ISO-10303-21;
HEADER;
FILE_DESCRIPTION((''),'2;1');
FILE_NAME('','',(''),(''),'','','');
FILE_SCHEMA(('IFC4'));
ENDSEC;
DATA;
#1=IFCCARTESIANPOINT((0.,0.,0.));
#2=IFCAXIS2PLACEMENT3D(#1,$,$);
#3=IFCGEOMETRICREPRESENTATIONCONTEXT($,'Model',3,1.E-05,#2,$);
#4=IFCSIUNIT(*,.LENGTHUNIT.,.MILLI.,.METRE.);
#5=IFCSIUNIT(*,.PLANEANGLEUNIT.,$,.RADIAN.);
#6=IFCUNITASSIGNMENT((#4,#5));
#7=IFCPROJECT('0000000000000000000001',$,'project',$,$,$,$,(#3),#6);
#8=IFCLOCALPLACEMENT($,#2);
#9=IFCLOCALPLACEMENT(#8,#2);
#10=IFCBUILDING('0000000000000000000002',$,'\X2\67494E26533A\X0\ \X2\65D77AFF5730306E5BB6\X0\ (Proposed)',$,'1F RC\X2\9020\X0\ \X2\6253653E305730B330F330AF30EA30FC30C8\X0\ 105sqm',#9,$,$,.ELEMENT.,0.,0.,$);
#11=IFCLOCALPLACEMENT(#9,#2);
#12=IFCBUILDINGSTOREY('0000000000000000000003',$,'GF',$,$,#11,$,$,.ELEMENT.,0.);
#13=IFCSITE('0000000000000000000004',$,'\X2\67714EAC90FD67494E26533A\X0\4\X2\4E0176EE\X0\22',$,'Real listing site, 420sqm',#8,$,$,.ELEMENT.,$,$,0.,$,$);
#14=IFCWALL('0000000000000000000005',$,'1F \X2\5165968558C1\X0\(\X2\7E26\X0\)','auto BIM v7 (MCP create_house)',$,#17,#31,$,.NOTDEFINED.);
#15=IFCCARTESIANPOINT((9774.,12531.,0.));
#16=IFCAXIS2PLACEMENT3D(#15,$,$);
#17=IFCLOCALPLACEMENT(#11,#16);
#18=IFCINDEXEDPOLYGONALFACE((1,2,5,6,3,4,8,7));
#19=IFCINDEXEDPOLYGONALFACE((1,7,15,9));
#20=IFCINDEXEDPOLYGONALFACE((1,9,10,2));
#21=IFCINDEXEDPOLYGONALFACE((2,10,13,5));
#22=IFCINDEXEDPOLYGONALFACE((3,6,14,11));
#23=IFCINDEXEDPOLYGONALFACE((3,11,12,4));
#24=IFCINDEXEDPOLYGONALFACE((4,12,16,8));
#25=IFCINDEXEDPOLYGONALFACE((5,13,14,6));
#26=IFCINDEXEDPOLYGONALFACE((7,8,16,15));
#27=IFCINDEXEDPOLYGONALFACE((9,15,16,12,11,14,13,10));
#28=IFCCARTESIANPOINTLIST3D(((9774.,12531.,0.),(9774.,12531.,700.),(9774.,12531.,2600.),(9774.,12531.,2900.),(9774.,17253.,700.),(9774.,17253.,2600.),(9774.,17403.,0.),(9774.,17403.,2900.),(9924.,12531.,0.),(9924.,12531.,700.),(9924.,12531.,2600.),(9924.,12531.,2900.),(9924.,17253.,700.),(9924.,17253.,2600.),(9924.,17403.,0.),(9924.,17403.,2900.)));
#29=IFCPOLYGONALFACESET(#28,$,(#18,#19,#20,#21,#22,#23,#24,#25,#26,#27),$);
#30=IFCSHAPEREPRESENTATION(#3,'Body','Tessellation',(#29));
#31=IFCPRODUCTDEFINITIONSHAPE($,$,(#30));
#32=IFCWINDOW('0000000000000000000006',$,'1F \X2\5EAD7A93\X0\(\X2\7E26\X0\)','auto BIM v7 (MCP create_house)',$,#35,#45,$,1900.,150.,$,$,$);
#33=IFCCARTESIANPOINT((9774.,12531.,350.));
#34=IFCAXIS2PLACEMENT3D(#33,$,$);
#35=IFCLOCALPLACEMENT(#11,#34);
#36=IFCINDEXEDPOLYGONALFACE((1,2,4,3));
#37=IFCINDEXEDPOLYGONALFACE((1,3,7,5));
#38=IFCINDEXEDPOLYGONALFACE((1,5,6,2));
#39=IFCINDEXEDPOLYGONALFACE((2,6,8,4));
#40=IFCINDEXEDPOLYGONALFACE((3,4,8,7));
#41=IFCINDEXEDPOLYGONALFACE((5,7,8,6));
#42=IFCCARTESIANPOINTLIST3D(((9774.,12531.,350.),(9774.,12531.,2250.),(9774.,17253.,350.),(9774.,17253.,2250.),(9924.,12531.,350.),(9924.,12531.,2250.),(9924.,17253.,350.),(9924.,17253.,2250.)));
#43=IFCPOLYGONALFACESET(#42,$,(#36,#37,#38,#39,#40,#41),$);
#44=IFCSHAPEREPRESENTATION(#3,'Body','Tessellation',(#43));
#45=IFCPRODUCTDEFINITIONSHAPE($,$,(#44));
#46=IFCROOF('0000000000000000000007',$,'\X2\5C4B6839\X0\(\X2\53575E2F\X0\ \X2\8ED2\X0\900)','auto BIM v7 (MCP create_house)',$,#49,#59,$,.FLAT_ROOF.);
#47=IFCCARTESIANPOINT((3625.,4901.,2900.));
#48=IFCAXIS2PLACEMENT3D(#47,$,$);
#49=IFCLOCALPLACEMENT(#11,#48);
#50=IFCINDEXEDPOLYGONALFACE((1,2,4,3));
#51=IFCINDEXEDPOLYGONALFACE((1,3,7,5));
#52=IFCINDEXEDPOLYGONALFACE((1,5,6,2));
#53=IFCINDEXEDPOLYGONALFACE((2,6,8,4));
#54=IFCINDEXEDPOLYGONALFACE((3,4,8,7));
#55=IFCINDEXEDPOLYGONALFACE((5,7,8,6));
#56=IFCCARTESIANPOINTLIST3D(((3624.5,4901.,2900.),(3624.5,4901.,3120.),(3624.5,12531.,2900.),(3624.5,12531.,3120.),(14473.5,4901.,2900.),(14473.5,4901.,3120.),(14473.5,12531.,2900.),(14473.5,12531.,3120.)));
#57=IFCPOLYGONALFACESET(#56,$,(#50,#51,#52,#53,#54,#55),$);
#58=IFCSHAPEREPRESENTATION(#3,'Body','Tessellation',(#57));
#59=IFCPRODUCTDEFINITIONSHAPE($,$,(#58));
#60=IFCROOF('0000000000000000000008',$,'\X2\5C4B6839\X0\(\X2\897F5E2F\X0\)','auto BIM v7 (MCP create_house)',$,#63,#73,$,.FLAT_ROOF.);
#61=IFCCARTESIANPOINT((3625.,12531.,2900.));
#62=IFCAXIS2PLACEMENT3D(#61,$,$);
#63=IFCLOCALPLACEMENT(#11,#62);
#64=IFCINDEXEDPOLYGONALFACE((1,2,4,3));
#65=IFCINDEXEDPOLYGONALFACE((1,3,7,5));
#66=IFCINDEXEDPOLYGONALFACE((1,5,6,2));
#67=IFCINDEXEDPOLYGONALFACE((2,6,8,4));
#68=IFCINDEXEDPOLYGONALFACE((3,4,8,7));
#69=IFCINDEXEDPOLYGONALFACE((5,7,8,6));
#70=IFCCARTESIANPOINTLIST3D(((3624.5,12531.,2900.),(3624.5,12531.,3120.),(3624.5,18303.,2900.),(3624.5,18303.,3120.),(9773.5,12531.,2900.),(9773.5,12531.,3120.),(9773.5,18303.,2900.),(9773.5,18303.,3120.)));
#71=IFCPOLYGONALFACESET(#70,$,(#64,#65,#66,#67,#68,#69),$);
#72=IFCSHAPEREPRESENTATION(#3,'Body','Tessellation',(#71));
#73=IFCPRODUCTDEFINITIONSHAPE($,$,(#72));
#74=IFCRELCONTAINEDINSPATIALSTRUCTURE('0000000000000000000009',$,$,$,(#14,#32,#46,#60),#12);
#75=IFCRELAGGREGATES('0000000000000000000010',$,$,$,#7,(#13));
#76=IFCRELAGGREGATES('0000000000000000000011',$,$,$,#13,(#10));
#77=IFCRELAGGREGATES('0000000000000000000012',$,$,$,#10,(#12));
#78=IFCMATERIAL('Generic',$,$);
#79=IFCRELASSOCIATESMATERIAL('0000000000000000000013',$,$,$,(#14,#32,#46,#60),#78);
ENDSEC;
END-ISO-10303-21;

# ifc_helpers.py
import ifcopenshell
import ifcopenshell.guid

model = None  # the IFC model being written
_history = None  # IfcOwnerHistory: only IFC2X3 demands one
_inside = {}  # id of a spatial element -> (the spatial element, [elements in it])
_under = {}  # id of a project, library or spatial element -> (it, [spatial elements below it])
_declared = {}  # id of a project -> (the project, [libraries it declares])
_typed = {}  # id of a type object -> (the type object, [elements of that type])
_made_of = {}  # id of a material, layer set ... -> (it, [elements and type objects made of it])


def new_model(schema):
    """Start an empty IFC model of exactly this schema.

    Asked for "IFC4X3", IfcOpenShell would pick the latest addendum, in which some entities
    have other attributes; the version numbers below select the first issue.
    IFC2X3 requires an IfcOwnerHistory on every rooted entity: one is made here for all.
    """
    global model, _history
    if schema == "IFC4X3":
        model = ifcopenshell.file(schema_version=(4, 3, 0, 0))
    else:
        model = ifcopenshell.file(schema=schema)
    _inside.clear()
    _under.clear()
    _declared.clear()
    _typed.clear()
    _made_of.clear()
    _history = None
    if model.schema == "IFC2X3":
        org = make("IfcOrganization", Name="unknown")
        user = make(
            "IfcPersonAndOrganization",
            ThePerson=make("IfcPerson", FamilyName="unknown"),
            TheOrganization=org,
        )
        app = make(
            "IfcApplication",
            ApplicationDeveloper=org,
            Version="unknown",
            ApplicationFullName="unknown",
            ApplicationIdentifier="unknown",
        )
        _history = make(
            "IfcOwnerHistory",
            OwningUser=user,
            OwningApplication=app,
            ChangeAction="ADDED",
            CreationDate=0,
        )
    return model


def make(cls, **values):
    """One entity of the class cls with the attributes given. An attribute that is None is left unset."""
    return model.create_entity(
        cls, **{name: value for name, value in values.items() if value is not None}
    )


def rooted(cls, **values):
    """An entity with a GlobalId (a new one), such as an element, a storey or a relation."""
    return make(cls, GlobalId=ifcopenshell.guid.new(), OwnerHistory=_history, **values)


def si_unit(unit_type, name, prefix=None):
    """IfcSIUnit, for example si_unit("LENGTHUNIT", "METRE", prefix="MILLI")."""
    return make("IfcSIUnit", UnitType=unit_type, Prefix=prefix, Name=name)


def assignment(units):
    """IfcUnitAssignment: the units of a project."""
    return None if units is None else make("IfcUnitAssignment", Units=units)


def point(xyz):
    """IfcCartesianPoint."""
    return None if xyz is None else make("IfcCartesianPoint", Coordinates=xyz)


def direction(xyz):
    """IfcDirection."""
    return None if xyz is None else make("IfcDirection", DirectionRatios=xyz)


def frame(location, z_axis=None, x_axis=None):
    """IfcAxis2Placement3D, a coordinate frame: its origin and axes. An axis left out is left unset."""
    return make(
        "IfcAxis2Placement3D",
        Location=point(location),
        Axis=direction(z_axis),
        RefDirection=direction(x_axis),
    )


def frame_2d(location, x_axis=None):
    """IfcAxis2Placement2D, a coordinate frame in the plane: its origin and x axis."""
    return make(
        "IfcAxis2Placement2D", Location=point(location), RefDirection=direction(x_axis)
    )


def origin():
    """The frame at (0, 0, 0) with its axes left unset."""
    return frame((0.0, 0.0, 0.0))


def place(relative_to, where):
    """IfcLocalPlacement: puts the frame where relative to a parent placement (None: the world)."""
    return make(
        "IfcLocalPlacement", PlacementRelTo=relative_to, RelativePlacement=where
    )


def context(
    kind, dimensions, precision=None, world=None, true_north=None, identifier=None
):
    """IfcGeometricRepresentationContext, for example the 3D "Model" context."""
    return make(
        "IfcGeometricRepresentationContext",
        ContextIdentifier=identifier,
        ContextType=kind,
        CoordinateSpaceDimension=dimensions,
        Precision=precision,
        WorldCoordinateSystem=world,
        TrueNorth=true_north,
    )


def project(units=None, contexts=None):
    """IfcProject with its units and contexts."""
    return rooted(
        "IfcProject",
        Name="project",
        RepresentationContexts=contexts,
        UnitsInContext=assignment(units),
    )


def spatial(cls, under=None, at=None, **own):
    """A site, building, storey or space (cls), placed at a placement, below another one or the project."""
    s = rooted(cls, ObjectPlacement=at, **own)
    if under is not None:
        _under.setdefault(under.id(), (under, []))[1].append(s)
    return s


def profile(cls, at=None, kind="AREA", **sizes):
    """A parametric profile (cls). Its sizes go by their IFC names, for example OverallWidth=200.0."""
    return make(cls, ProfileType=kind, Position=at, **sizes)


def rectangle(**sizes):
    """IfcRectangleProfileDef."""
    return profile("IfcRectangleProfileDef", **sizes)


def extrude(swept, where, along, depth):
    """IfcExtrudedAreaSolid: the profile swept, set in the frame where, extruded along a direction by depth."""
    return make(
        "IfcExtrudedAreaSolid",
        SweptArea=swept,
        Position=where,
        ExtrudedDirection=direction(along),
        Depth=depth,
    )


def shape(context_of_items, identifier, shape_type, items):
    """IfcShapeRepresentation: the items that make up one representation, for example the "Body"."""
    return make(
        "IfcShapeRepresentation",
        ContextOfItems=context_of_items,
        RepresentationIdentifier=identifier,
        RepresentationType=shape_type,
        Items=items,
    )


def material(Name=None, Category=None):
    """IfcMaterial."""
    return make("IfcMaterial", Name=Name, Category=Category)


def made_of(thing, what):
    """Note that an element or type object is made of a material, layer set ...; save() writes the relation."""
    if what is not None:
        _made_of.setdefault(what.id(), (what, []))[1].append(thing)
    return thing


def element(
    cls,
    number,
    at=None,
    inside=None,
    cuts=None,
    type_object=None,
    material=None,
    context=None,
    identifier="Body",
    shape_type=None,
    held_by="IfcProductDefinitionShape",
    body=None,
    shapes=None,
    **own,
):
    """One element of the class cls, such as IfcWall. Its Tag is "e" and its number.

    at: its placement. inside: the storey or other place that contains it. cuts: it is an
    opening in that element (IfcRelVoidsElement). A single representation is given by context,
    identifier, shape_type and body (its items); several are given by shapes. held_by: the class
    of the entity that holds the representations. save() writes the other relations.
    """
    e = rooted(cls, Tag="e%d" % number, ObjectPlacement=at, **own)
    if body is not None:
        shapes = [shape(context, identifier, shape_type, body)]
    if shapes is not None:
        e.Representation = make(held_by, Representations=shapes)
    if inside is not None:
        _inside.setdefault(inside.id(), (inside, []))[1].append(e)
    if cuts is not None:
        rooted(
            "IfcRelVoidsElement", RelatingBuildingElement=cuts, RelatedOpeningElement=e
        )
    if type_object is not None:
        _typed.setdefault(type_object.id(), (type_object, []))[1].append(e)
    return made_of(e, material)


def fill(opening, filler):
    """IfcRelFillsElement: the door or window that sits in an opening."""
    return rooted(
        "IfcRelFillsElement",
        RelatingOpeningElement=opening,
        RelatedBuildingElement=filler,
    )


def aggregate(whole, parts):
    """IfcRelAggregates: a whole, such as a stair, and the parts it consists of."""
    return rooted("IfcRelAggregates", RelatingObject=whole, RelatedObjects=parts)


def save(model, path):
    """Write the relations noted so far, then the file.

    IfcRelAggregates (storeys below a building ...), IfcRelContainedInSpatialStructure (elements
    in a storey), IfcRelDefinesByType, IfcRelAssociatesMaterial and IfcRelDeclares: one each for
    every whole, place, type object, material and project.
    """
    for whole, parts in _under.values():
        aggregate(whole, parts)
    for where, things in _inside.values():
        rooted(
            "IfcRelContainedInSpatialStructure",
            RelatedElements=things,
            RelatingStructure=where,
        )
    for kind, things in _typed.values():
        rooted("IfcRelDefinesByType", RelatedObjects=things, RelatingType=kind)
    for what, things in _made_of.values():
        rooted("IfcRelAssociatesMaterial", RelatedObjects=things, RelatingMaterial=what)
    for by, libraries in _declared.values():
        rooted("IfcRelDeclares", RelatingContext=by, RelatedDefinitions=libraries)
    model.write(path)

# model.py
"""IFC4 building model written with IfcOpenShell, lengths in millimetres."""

from ifc_helpers import new_model, si_unit, frame, frame_2d, origin, place, context, project, spatial, rectangle, extrude, material, element, fill, save


model = new_model("IFC4")

# Units and contexts
model_context = context("Model", 3, precision=1e-05, world=origin())
ifc_project = project(units=[si_unit("LENGTHUNIT", "METRE", prefix="MILLI"), si_unit("PLANEANGLEUNIT", "RADIAN")], contexts=[model_context])

# Site, building, storey
site_placement = place(None, origin())
site = spatial("IfcSite", under=ifc_project, at=site_placement, Name="東京都杉並区4丁目22", ObjectType="Real listing site, 420sqm", CompositionType="ELEMENT", RefElevation=0.0)
building_placement = place(site_placement, origin())
building = spatial("IfcBuilding", under=site, at=building_placement, Name="杉並区 旗竿地の家 (Proposed)", ObjectType="1F RC造 打放しコンクリート 105sqm", CompositionType="ELEMENT", ElevationOfRefHeight=0.0, ElevationOfTerrain=0.0)
storey_placement = place(building_placement, origin())
storey = spatial("IfcBuildingStorey", under=building, at=storey_placement, Name="GF", CompositionType="ELEMENT", Elevation=0.0)

# Shared definitions
ifc_material = material(Name="Generic")

# Wall, opening, window
wall_1_placement = place(storey_placement, frame((9774.0, 12531.0, 0.0)))
wall_1 = element("IfcWall", 1, at=wall_1_placement, inside=storey, material=ifc_material, Name="1F 入隅壁(縦)", Description="auto BIM v7 (MCP create_house)", PredefinedType="NOTDEFINED", context=model_context, shape_type="SweptSolid", body=[
    extrude(rectangle(XDim=150.0, YDim=4872.0, at=frame_2d((75.0, 2436.0))), frame((9774.0, 12531.0, 0.0)), (0.0, 0.0, 1.0), 2900.0),
])
opening_1_placement = place(storey_placement, frame((9774.0, 12531.0, 350.0)))
opening_1 = element("IfcOpeningElement", 2, at=opening_1_placement, cuts=wall_1, PredefinedType="NOTDEFINED", context=model_context, shape_type="SweptSolid", body=[
    extrude(rectangle(XDim=150.0, YDim=4722.0, at=frame_2d((75.0, 2361.0))), frame((9774.0, 12531.0, 350.0)), (0.0, 0.0, 1.0), 1900.0),
])
window_1_placement = place(storey_placement, frame((9774.0, 12531.0, 350.0)))
window_1 = element("IfcWindow", 3, at=window_1_placement, inside=storey, material=ifc_material, Name="1F 庭窓(縦)", Description="auto BIM v7 (MCP create_house)", OverallHeight=1900.0, OverallWidth=150.0, context=model_context, shape_type="SweptSolid", body=[
    extrude(rectangle(XDim=150.0, YDim=4722.0, at=frame_2d((75.0, 2361.0))), frame((9774.0, 12531.0, 350.0)), (0.0, 0.0, 1.0), 1900.0),
])
fill(opening_1, window_1)

# Roofs
roof_1_placement = place(storey_placement, frame((3625.0, 4901.0, 2900.0)))
element("IfcRoof", 4, at=roof_1_placement, inside=storey, material=ifc_material, Name="屋根(南帯 軒900)", Description="auto BIM v7 (MCP create_house)", PredefinedType="FLAT_ROOF", context=model_context, shape_type="SweptSolid", body=[
    extrude(rectangle(XDim=10849.0, YDim=7630.0, at=frame_2d((5424.0, 3815.0))), frame((3625.0, 4901.0, 2900.0)), (0.0, 0.0, 1.0), 220.0),
])
roof_2_placement = place(storey_placement, frame((3625.0, 12531.0, 2900.0)))
element("IfcRoof", 5, at=roof_2_placement, inside=storey, material=ifc_material, Name="屋根(西帯)", Description="auto BIM v7 (MCP create_house)", PredefinedType="FLAT_ROOF", context=model_context, shape_type="SweptSolid", body=[
    extrude(rectangle(XDim=6149.0, YDim=5772.0, at=frame_2d((3074.0, 2886.0))), frame((3625.0, 12531.0, 2900.0)), (0.0, 0.0, 1.0), 220.0),
])

save(model, "model.ifc")
